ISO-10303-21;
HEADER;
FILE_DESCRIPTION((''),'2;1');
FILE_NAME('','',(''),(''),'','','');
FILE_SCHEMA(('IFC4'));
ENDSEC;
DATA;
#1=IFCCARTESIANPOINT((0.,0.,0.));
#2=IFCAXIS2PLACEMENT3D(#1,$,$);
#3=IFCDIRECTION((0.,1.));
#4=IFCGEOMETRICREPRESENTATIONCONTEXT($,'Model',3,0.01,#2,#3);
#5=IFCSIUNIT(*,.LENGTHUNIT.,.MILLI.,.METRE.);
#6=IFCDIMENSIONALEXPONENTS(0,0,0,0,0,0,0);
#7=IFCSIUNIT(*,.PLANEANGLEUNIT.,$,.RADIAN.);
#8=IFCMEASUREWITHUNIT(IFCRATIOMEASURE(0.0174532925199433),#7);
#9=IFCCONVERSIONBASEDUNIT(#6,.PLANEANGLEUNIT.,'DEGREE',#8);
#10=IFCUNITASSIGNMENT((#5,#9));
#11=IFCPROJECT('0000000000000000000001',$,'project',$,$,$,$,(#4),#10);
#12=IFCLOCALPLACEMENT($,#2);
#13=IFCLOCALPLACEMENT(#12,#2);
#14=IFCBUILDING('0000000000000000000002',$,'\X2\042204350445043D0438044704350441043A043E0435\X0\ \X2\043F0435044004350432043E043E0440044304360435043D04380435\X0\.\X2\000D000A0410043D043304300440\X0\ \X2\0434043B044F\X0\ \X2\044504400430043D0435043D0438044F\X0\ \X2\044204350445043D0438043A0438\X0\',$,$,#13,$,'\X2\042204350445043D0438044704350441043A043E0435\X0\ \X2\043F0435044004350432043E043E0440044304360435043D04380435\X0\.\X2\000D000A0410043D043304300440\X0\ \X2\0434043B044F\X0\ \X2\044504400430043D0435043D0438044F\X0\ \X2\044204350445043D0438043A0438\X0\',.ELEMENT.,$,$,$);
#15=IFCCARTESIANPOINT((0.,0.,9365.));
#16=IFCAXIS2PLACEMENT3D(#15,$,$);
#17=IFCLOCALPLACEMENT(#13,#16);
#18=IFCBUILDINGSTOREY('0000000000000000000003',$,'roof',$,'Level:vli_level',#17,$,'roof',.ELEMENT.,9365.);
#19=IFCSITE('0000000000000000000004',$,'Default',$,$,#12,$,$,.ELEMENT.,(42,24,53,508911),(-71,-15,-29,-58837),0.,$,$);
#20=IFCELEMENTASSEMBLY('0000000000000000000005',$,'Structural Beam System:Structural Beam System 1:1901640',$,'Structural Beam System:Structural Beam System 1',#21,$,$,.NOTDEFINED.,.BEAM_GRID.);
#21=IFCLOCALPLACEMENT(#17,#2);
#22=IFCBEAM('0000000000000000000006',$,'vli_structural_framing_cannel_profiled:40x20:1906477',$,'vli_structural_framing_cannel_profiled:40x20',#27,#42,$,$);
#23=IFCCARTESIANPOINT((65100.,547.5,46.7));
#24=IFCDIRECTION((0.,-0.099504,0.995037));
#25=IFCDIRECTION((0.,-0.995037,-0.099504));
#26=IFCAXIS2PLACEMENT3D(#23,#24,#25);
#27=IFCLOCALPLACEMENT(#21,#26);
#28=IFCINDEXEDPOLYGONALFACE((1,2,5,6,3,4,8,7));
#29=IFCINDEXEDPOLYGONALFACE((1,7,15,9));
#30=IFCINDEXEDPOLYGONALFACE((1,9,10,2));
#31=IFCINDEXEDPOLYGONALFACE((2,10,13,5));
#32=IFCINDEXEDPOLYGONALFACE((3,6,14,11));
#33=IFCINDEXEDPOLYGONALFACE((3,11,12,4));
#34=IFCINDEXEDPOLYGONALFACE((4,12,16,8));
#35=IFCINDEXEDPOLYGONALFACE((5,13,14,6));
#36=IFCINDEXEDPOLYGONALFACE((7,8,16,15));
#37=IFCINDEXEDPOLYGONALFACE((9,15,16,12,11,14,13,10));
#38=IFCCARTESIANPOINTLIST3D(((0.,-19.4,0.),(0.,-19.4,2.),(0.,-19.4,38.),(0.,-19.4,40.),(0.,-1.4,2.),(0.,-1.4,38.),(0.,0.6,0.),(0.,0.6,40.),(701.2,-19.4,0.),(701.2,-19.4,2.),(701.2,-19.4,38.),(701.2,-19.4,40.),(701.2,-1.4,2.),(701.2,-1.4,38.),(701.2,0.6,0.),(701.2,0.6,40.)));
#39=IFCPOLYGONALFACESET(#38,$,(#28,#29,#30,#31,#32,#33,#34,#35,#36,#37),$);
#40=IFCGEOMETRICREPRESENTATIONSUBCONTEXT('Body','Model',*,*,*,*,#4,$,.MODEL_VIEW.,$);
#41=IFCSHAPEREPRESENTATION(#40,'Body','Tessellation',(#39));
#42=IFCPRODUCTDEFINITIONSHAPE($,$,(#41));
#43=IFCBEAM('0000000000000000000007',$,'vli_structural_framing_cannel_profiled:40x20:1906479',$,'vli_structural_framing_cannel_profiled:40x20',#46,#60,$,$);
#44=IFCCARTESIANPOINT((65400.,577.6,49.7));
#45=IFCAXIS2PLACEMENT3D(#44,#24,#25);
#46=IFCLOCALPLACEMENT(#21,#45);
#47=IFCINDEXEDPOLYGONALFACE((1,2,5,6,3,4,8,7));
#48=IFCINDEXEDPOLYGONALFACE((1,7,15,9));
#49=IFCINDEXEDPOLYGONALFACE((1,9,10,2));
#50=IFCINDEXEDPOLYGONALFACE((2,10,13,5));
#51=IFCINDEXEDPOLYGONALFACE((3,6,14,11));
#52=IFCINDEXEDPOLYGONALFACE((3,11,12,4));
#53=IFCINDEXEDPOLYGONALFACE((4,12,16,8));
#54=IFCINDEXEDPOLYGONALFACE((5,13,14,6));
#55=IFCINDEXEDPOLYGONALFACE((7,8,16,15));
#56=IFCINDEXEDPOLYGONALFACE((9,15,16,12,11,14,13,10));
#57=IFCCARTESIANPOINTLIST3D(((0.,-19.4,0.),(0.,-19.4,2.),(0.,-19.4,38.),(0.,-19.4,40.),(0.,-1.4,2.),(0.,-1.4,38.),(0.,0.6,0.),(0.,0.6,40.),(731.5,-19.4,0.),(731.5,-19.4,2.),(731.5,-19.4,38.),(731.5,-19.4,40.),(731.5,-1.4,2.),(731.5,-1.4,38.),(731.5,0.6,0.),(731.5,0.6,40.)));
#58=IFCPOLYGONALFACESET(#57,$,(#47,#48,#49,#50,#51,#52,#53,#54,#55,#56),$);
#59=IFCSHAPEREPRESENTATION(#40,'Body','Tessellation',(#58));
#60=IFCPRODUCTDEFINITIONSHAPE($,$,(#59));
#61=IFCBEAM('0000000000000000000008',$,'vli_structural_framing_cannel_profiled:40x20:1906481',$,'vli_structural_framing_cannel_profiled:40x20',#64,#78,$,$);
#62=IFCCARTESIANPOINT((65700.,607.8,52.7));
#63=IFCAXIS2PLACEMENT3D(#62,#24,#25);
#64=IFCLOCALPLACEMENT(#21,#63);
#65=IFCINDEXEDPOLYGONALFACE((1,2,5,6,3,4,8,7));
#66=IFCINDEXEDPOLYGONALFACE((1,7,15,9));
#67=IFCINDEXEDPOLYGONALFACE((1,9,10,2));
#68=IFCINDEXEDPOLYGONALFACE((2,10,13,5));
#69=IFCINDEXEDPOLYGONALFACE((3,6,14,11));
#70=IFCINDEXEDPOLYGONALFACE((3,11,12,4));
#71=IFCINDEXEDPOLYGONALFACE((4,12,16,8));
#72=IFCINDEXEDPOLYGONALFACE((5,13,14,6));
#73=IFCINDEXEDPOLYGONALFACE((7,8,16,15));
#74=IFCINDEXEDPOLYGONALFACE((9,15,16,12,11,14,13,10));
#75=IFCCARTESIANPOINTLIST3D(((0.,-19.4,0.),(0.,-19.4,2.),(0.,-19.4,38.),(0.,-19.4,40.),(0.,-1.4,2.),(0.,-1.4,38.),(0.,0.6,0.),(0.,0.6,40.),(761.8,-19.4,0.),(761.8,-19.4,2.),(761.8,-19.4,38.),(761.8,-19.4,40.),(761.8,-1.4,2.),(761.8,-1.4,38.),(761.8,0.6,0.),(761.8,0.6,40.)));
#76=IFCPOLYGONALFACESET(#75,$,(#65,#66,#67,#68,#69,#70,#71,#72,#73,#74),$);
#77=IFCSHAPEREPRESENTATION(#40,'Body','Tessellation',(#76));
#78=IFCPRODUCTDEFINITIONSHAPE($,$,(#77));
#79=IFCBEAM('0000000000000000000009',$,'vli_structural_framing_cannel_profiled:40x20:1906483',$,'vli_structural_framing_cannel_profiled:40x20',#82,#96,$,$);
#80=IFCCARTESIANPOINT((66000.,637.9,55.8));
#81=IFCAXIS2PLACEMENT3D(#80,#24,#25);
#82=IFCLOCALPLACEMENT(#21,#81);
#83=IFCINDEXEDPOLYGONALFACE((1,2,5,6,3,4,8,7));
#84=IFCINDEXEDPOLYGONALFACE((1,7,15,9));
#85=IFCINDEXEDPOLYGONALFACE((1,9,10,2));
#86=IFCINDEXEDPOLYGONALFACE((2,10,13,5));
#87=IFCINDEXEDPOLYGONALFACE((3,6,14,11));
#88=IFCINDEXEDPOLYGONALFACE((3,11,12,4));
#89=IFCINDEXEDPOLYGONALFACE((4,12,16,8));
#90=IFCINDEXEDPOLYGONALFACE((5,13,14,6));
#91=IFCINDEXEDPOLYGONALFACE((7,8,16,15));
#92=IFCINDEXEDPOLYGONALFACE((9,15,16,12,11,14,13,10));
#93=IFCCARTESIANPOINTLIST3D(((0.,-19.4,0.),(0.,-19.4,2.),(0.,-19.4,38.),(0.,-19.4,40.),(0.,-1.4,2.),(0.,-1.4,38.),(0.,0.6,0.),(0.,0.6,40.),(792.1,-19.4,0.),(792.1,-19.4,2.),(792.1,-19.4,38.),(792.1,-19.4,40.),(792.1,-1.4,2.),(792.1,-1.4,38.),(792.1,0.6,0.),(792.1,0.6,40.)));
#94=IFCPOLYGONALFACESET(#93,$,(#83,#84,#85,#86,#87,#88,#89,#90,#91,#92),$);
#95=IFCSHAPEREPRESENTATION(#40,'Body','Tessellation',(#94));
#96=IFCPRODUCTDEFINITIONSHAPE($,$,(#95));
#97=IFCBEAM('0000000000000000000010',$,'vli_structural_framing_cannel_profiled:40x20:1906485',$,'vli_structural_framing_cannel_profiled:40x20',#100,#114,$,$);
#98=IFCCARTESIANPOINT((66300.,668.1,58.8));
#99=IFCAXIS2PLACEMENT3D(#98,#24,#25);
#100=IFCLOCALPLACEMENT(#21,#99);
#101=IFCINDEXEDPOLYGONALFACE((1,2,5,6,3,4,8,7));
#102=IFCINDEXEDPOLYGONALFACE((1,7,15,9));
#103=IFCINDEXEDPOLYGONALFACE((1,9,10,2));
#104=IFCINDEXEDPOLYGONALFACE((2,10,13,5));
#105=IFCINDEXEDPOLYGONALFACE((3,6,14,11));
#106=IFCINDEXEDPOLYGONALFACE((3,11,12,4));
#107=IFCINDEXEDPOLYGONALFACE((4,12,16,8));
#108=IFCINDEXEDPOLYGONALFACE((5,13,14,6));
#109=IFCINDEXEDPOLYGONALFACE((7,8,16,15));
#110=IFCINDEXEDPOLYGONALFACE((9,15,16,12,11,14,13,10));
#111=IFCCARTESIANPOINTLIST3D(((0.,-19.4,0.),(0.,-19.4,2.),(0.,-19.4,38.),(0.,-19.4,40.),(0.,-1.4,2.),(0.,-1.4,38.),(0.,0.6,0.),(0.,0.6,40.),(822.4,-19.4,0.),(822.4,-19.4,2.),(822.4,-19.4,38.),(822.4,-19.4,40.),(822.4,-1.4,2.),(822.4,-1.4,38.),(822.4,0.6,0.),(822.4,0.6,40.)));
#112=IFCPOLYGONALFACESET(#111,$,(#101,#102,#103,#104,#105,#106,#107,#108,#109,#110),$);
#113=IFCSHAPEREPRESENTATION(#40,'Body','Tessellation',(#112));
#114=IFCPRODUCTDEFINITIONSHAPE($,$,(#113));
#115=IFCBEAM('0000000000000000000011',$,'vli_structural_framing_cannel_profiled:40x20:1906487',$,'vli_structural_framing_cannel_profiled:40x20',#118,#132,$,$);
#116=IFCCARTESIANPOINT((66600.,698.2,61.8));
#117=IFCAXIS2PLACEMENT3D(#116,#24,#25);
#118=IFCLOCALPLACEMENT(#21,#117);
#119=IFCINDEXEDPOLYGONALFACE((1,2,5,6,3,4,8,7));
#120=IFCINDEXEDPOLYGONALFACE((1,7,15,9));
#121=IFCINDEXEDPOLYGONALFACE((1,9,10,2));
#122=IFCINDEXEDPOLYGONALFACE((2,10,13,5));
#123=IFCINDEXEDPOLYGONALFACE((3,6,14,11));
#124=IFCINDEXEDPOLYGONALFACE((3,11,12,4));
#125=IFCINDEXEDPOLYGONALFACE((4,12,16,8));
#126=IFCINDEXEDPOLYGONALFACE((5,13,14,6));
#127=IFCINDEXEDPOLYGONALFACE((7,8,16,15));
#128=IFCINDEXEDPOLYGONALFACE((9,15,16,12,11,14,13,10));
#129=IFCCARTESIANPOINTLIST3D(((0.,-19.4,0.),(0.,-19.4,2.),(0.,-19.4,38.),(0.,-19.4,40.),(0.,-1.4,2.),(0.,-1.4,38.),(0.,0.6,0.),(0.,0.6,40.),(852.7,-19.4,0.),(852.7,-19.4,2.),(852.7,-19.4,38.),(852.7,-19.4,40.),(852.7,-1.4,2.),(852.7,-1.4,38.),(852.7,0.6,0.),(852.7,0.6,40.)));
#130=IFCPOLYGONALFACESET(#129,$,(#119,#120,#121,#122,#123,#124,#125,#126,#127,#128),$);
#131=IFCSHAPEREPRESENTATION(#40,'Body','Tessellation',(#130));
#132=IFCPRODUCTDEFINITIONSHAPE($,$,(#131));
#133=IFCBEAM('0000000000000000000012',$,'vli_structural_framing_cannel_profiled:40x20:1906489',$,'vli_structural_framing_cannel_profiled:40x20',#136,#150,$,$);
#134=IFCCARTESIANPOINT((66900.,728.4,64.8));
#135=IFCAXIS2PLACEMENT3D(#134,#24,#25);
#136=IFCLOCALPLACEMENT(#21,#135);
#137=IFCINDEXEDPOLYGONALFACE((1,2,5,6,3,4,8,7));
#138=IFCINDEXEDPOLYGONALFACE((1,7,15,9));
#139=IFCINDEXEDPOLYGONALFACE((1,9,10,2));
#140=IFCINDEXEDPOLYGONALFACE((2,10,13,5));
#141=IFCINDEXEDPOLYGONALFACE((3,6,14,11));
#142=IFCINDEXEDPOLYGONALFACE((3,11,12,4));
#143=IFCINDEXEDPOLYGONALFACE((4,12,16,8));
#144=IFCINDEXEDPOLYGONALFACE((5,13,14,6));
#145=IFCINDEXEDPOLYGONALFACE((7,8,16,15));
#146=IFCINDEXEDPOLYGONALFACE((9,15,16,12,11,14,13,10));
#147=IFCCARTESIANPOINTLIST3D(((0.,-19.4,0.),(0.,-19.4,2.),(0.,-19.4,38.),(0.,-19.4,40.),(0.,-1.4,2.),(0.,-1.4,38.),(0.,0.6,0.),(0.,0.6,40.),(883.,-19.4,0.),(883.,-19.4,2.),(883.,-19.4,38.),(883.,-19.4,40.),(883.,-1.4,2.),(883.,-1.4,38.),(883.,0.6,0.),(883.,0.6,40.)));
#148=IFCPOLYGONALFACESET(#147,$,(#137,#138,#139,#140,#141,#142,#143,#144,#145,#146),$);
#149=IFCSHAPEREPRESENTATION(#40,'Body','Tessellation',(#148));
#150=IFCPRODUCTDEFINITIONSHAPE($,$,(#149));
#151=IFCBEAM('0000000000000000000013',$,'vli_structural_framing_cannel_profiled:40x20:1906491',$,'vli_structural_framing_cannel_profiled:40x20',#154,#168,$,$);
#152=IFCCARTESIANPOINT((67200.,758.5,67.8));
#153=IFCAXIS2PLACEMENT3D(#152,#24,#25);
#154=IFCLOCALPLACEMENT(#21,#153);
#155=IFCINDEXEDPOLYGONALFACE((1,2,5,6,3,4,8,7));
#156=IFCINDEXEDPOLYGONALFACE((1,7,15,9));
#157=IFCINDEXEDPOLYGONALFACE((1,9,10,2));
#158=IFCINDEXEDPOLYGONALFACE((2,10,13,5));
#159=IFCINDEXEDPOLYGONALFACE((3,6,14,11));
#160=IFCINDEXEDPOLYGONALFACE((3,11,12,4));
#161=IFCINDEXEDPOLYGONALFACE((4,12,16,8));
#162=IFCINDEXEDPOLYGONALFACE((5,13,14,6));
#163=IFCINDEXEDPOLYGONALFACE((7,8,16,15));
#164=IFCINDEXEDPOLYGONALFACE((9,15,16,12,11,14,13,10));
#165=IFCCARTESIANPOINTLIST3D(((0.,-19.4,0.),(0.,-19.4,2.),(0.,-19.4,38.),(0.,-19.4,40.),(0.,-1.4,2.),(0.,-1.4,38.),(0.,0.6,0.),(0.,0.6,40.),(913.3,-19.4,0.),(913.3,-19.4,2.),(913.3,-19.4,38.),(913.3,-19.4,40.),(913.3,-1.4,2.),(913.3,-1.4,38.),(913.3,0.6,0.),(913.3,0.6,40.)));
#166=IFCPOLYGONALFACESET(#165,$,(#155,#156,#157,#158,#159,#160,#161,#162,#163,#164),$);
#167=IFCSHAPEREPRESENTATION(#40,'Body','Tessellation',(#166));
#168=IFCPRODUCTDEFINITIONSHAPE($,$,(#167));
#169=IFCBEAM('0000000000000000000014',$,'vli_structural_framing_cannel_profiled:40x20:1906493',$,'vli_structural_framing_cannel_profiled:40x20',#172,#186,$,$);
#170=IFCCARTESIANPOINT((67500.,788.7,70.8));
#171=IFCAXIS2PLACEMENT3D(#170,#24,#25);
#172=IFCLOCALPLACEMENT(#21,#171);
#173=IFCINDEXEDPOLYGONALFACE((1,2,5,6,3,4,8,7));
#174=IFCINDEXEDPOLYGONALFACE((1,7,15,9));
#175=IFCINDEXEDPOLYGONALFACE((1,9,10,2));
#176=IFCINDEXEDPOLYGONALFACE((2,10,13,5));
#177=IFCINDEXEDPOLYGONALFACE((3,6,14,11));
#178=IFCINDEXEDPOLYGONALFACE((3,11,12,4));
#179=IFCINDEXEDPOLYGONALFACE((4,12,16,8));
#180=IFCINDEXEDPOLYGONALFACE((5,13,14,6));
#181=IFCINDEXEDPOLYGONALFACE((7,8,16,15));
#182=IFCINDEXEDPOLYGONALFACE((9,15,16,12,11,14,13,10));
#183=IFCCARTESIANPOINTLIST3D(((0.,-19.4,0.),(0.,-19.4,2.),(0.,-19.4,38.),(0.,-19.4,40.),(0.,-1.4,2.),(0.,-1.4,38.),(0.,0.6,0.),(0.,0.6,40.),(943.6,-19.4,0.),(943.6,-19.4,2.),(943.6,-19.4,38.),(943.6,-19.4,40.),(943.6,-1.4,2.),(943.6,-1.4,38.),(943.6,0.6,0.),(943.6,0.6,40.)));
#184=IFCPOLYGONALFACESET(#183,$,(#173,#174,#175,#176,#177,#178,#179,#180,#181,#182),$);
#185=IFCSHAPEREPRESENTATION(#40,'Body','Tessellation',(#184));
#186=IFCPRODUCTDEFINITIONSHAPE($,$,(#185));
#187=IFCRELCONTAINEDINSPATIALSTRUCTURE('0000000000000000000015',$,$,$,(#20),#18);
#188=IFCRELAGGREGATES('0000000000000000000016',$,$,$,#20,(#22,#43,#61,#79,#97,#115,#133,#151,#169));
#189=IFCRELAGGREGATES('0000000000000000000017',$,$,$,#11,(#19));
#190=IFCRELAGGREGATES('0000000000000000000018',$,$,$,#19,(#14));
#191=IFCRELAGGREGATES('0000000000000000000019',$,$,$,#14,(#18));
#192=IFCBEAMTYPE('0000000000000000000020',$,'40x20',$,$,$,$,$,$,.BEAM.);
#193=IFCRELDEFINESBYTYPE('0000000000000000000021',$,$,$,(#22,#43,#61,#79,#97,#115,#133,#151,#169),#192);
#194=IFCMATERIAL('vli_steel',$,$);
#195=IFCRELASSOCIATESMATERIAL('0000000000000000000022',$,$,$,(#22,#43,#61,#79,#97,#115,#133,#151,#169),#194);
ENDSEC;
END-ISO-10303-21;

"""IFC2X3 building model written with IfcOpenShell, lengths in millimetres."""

from ifc_helpers import new_model, entity, si_unit, converted_unit, direction, frame, origin, place, context, subcontext, project, spatial, polyline, outline, extrude, material, type_object, element, aggregate, save


model = new_model("IFC2X3")

# Units and contexts
model_context = context("Model", 3, precision=0.01, world=origin(), true_north=direction((0.0, 1.0)))
body_context = subcontext(model_context, "Body", "Model", "MODEL_VIEW")
ifc_project = project(units=[si_unit("LENGTHUNIT", "METRE", prefix="MILLI"), converted_unit("PLANEANGLEUNIT", "DEGREE", entity("IfcRatioMeasure", 0.0174532925199433), si_unit("PLANEANGLEUNIT", "RADIAN"), dimensions=[0, 0, 0, 0, 0, 0, 0])], contexts=[model_context])

# Site, building, storey
site_placement = place(None, origin())
site = spatial("IfcSite", under=ifc_project, at=site_placement, Name="Default", CompositionType="ELEMENT", RefLatitude=(42, 24, 53, 508911), RefLongitude=(-71, -15, -29, -58837), RefElevation=0.0)
building_placement = place(site_placement, origin())
building = spatial("IfcBuilding", under=site, at=building_placement, Name="Техническое перевооружение.\r\nАнгар для хранения техники", LongName="Техническое перевооружение.\r\nАнгар для хранения техники", CompositionType="ELEMENT")
storey_placement = place(building_placement, frame((0.0, 0.0, 9365.0)))
storey = spatial("IfcBuildingStorey", under=building, at=storey_placement, Name="roof", ObjectType="Level:vli_level", LongName="roof", CompositionType="ELEMENT", Elevation=9365.0)

# Element assembly, beams
assembly_1_placement = place(storey_placement, origin())
assembly_1 = element("IfcElementAssembly", 1, at=assembly_1_placement, inside=storey, Name="Structural Beam System:Structural Beam System 1:1901640", ObjectType="Structural Beam System:Structural Beam System 1", AssemblyPlace="NOTDEFINED", PredefinedType="BEAM_GRID")
ifc_material = material(Name="vli_steel")
beam_type = type_object("IfcBeamType", Name="40x20", PredefinedType="BEAM")
beam_1_placement = place(assembly_1_placement, frame((65100.0, 547.5, 46.7), z_axis=(0.0, -0.099504, 0.995037), x_axis=(0.0, -0.995037, -0.099504)))
beam_1 = element("IfcBeam", 2, at=beam_1_placement, type_object=beam_type, material=ifc_material, Name="vli_structural_framing_cannel_profiled:40x20:1906477", ObjectType="vli_structural_framing_cannel_profiled:40x20", context=body_context, shape_type="SweptSolid", body=[
    extrude(outline(polyline([(-20.0, -9.5), (-18.0, -9.5), (-18.0, 8.5), (18.0, 8.5), (18.0, -9.5), (20.0, -9.5), (20.0, 10.5), (-20.0, 10.5), (-20.0, -9.5)])), frame((0.0, -9.9, 20.0), z_axis=(1.0, 0.0, 0.0), x_axis=(0.0, 0.0, -1.0)), (0.0, 0.0, 1.0), 701.2),
])
beam_2_placement = place(assembly_1_placement, frame((65400.0, 577.6, 49.7), z_axis=(0.0, -0.099504, 0.995037), x_axis=(0.0, -0.995037, -0.099504)))
beam_2 = element("IfcBeam", 3, at=beam_2_placement, type_object=beam_type, material=ifc_material, Name="vli_structural_framing_cannel_profiled:40x20:1906479", ObjectType="vli_structural_framing_cannel_profiled:40x20", context=body_context, shape_type="SweptSolid", body=[
    extrude(outline(polyline([(-20.0, -9.5), (-18.0, -9.5), (-18.0, 8.5), (18.0, 8.5), (18.0, -9.5), (20.0, -9.5), (20.0, 10.5), (-20.0, 10.5), (-20.0, -9.5)])), frame((0.0, -9.9, 20.0), z_axis=(1.0, 0.0, 0.0), x_axis=(0.0, 0.0, -1.0)), (0.0, 0.0, 1.0), 731.5),
])
beam_3_placement = place(assembly_1_placement, frame((65700.0, 607.8, 52.7), z_axis=(0.0, -0.099504, 0.995037), x_axis=(0.0, -0.995037, -0.099504)))
beam_3 = element("IfcBeam", 4, at=beam_3_placement, type_object=beam_type, material=ifc_material, Name="vli_structural_framing_cannel_profiled:40x20:1906481", ObjectType="vli_structural_framing_cannel_profiled:40x20", context=body_context, shape_type="SweptSolid", body=[
    extrude(outline(polyline([(-20.0, -9.5), (-18.0, -9.5), (-18.0, 8.5), (18.0, 8.5), (18.0, -9.5), (20.0, -9.5), (20.0, 10.5), (-20.0, 10.5), (-20.0, -9.5)])), frame((0.0, -9.9, 20.0), z_axis=(1.0, 0.0, 0.0), x_axis=(0.0, 0.0, -1.0)), (0.0, 0.0, 1.0), 761.8),
])
beam_4_placement = place(assembly_1_placement, frame((66000.0, 637.9, 55.8), z_axis=(0.0, -0.099504, 0.995037), x_axis=(0.0, -0.995037, -0.099504)))
beam_4 = element("IfcBeam", 5, at=beam_4_placement, type_object=beam_type, material=ifc_material, Name="vli_structural_framing_cannel_profiled:40x20:1906483", ObjectType="vli_structural_framing_cannel_profiled:40x20", context=body_context, shape_type="SweptSolid", body=[
    extrude(outline(polyline([(-20.0, -9.5), (-18.0, -9.5), (-18.0, 8.5), (18.0, 8.5), (18.0, -9.5), (20.0, -9.5), (20.0, 10.5), (-20.0, 10.5), (-20.0, -9.5)])), frame((0.0, -9.9, 20.0), z_axis=(1.0, 0.0, 0.0), x_axis=(0.0, 0.0, -1.0)), (0.0, 0.0, 1.0), 792.1),
])
beam_5_placement = place(assembly_1_placement, frame((66300.0, 668.1, 58.8), z_axis=(0.0, -0.099504, 0.995037), x_axis=(0.0, -0.995037, -0.099504)))
beam_5 = element("IfcBeam", 6, at=beam_5_placement, type_object=beam_type, material=ifc_material, Name="vli_structural_framing_cannel_profiled:40x20:1906485", ObjectType="vli_structural_framing_cannel_profiled:40x20", context=body_context, shape_type="SweptSolid", body=[
    extrude(outline(polyline([(-20.0, -9.5), (-18.0, -9.5), (-18.0, 8.5), (18.0, 8.5), (18.0, -9.5), (20.0, -9.5), (20.0, 10.5), (-20.0, 10.5), (-20.0, -9.5)])), frame((0.0, -9.9, 20.0), z_axis=(1.0, 0.0, 0.0), x_axis=(0.0, 0.0, -1.0)), (0.0, 0.0, 1.0), 822.4),
])
beam_6_placement = place(assembly_1_placement, frame((66600.0, 698.2, 61.8), z_axis=(0.0, -0.099504, 0.995037), x_axis=(0.0, -0.995037, -0.099504)))
beam_6 = element("IfcBeam", 7, at=beam_6_placement, type_object=beam_type, material=ifc_material, Name="vli_structural_framing_cannel_profiled:40x20:1906487", ObjectType="vli_structural_framing_cannel_profiled:40x20", context=body_context, shape_type="SweptSolid", body=[
    extrude(outline(polyline([(-20.0, -9.5), (-18.0, -9.5), (-18.0, 8.5), (18.0, 8.5), (18.0, -9.5), (20.0, -9.5), (20.0, 10.5), (-20.0, 10.5), (-20.0, -9.5)])), frame((0.0, -9.9, 20.0), z_axis=(1.0, 0.0, 0.0), x_axis=(0.0, 0.0, -1.0)), (0.0, 0.0, 1.0), 852.7),
])
beam_7_placement = place(assembly_1_placement, frame((66900.0, 728.4, 64.8), z_axis=(0.0, -0.099504, 0.995037), x_axis=(0.0, -0.995037, -0.099504)))
beam_7 = element("IfcBeam", 8, at=beam_7_placement, type_object=beam_type, material=ifc_material, Name="vli_structural_framing_cannel_profiled:40x20:1906489", ObjectType="vli_structural_framing_cannel_profiled:40x20", context=body_context, shape_type="SweptSolid", body=[
    extrude(outline(polyline([(-20.0, -9.5), (-18.0, -9.5), (-18.0, 8.5), (18.0, 8.5), (18.0, -9.5), (20.0, -9.5), (20.0, 10.5), (-20.0, 10.5), (-20.0, -9.5)])), frame((0.0, -9.9, 20.0), z_axis=(1.0, 0.0, 0.0), x_axis=(0.0, 0.0, -1.0)), (0.0, 0.0, 1.0), 883.0),
])
beam_8_placement = place(assembly_1_placement, frame((67200.0, 758.5, 67.8), z_axis=(0.0, -0.099504, 0.995037), x_axis=(0.0, -0.995037, -0.099504)))
beam_8 = element("IfcBeam", 9, at=beam_8_placement, type_object=beam_type, material=ifc_material, Name="vli_structural_framing_cannel_profiled:40x20:1906491", ObjectType="vli_structural_framing_cannel_profiled:40x20", context=body_context, shape_type="SweptSolid", body=[
    extrude(outline(polyline([(-20.0, -9.5), (-18.0, -9.5), (-18.0, 8.5), (18.0, 8.5), (18.0, -9.5), (20.0, -9.5), (20.0, 10.5), (-20.0, 10.5), (-20.0, -9.5)])), frame((0.0, -9.9, 20.0), z_axis=(1.0, 0.0, 0.0), x_axis=(0.0, 0.0, -1.0)), (0.0, 0.0, 1.0), 913.3),
])
beam_9_placement = place(assembly_1_placement, frame((67500.0, 788.7, 70.8), z_axis=(0.0, -0.099504, 0.995037), x_axis=(0.0, -0.995037, -0.099504)))
beam_9 = element("IfcBeam", 10, at=beam_9_placement, type_object=beam_type, material=ifc_material, Name="vli_structural_framing_cannel_profiled:40x20:1906493", ObjectType="vli_structural_framing_cannel_profiled:40x20", context=body_context, shape_type="SweptSolid", body=[
    extrude(outline(polyline([(-20.0, -9.5), (-18.0, -9.5), (-18.0, 8.5), (18.0, 8.5), (18.0, -9.5), (20.0, -9.5), (20.0, 10.5), (-20.0, 10.5), (-20.0, -9.5)])), frame((0.0, -9.9, 20.0), z_axis=(1.0, 0.0, 0.0), x_axis=(0.0, 0.0, -1.0)), (0.0, 0.0, 1.0), 943.6),
])
aggregate(assembly_1, [beam_1, beam_2, beam_3, beam_4, beam_5, beam_6, beam_7, beam_8, beam_9])

save(model, "model.ifc")
